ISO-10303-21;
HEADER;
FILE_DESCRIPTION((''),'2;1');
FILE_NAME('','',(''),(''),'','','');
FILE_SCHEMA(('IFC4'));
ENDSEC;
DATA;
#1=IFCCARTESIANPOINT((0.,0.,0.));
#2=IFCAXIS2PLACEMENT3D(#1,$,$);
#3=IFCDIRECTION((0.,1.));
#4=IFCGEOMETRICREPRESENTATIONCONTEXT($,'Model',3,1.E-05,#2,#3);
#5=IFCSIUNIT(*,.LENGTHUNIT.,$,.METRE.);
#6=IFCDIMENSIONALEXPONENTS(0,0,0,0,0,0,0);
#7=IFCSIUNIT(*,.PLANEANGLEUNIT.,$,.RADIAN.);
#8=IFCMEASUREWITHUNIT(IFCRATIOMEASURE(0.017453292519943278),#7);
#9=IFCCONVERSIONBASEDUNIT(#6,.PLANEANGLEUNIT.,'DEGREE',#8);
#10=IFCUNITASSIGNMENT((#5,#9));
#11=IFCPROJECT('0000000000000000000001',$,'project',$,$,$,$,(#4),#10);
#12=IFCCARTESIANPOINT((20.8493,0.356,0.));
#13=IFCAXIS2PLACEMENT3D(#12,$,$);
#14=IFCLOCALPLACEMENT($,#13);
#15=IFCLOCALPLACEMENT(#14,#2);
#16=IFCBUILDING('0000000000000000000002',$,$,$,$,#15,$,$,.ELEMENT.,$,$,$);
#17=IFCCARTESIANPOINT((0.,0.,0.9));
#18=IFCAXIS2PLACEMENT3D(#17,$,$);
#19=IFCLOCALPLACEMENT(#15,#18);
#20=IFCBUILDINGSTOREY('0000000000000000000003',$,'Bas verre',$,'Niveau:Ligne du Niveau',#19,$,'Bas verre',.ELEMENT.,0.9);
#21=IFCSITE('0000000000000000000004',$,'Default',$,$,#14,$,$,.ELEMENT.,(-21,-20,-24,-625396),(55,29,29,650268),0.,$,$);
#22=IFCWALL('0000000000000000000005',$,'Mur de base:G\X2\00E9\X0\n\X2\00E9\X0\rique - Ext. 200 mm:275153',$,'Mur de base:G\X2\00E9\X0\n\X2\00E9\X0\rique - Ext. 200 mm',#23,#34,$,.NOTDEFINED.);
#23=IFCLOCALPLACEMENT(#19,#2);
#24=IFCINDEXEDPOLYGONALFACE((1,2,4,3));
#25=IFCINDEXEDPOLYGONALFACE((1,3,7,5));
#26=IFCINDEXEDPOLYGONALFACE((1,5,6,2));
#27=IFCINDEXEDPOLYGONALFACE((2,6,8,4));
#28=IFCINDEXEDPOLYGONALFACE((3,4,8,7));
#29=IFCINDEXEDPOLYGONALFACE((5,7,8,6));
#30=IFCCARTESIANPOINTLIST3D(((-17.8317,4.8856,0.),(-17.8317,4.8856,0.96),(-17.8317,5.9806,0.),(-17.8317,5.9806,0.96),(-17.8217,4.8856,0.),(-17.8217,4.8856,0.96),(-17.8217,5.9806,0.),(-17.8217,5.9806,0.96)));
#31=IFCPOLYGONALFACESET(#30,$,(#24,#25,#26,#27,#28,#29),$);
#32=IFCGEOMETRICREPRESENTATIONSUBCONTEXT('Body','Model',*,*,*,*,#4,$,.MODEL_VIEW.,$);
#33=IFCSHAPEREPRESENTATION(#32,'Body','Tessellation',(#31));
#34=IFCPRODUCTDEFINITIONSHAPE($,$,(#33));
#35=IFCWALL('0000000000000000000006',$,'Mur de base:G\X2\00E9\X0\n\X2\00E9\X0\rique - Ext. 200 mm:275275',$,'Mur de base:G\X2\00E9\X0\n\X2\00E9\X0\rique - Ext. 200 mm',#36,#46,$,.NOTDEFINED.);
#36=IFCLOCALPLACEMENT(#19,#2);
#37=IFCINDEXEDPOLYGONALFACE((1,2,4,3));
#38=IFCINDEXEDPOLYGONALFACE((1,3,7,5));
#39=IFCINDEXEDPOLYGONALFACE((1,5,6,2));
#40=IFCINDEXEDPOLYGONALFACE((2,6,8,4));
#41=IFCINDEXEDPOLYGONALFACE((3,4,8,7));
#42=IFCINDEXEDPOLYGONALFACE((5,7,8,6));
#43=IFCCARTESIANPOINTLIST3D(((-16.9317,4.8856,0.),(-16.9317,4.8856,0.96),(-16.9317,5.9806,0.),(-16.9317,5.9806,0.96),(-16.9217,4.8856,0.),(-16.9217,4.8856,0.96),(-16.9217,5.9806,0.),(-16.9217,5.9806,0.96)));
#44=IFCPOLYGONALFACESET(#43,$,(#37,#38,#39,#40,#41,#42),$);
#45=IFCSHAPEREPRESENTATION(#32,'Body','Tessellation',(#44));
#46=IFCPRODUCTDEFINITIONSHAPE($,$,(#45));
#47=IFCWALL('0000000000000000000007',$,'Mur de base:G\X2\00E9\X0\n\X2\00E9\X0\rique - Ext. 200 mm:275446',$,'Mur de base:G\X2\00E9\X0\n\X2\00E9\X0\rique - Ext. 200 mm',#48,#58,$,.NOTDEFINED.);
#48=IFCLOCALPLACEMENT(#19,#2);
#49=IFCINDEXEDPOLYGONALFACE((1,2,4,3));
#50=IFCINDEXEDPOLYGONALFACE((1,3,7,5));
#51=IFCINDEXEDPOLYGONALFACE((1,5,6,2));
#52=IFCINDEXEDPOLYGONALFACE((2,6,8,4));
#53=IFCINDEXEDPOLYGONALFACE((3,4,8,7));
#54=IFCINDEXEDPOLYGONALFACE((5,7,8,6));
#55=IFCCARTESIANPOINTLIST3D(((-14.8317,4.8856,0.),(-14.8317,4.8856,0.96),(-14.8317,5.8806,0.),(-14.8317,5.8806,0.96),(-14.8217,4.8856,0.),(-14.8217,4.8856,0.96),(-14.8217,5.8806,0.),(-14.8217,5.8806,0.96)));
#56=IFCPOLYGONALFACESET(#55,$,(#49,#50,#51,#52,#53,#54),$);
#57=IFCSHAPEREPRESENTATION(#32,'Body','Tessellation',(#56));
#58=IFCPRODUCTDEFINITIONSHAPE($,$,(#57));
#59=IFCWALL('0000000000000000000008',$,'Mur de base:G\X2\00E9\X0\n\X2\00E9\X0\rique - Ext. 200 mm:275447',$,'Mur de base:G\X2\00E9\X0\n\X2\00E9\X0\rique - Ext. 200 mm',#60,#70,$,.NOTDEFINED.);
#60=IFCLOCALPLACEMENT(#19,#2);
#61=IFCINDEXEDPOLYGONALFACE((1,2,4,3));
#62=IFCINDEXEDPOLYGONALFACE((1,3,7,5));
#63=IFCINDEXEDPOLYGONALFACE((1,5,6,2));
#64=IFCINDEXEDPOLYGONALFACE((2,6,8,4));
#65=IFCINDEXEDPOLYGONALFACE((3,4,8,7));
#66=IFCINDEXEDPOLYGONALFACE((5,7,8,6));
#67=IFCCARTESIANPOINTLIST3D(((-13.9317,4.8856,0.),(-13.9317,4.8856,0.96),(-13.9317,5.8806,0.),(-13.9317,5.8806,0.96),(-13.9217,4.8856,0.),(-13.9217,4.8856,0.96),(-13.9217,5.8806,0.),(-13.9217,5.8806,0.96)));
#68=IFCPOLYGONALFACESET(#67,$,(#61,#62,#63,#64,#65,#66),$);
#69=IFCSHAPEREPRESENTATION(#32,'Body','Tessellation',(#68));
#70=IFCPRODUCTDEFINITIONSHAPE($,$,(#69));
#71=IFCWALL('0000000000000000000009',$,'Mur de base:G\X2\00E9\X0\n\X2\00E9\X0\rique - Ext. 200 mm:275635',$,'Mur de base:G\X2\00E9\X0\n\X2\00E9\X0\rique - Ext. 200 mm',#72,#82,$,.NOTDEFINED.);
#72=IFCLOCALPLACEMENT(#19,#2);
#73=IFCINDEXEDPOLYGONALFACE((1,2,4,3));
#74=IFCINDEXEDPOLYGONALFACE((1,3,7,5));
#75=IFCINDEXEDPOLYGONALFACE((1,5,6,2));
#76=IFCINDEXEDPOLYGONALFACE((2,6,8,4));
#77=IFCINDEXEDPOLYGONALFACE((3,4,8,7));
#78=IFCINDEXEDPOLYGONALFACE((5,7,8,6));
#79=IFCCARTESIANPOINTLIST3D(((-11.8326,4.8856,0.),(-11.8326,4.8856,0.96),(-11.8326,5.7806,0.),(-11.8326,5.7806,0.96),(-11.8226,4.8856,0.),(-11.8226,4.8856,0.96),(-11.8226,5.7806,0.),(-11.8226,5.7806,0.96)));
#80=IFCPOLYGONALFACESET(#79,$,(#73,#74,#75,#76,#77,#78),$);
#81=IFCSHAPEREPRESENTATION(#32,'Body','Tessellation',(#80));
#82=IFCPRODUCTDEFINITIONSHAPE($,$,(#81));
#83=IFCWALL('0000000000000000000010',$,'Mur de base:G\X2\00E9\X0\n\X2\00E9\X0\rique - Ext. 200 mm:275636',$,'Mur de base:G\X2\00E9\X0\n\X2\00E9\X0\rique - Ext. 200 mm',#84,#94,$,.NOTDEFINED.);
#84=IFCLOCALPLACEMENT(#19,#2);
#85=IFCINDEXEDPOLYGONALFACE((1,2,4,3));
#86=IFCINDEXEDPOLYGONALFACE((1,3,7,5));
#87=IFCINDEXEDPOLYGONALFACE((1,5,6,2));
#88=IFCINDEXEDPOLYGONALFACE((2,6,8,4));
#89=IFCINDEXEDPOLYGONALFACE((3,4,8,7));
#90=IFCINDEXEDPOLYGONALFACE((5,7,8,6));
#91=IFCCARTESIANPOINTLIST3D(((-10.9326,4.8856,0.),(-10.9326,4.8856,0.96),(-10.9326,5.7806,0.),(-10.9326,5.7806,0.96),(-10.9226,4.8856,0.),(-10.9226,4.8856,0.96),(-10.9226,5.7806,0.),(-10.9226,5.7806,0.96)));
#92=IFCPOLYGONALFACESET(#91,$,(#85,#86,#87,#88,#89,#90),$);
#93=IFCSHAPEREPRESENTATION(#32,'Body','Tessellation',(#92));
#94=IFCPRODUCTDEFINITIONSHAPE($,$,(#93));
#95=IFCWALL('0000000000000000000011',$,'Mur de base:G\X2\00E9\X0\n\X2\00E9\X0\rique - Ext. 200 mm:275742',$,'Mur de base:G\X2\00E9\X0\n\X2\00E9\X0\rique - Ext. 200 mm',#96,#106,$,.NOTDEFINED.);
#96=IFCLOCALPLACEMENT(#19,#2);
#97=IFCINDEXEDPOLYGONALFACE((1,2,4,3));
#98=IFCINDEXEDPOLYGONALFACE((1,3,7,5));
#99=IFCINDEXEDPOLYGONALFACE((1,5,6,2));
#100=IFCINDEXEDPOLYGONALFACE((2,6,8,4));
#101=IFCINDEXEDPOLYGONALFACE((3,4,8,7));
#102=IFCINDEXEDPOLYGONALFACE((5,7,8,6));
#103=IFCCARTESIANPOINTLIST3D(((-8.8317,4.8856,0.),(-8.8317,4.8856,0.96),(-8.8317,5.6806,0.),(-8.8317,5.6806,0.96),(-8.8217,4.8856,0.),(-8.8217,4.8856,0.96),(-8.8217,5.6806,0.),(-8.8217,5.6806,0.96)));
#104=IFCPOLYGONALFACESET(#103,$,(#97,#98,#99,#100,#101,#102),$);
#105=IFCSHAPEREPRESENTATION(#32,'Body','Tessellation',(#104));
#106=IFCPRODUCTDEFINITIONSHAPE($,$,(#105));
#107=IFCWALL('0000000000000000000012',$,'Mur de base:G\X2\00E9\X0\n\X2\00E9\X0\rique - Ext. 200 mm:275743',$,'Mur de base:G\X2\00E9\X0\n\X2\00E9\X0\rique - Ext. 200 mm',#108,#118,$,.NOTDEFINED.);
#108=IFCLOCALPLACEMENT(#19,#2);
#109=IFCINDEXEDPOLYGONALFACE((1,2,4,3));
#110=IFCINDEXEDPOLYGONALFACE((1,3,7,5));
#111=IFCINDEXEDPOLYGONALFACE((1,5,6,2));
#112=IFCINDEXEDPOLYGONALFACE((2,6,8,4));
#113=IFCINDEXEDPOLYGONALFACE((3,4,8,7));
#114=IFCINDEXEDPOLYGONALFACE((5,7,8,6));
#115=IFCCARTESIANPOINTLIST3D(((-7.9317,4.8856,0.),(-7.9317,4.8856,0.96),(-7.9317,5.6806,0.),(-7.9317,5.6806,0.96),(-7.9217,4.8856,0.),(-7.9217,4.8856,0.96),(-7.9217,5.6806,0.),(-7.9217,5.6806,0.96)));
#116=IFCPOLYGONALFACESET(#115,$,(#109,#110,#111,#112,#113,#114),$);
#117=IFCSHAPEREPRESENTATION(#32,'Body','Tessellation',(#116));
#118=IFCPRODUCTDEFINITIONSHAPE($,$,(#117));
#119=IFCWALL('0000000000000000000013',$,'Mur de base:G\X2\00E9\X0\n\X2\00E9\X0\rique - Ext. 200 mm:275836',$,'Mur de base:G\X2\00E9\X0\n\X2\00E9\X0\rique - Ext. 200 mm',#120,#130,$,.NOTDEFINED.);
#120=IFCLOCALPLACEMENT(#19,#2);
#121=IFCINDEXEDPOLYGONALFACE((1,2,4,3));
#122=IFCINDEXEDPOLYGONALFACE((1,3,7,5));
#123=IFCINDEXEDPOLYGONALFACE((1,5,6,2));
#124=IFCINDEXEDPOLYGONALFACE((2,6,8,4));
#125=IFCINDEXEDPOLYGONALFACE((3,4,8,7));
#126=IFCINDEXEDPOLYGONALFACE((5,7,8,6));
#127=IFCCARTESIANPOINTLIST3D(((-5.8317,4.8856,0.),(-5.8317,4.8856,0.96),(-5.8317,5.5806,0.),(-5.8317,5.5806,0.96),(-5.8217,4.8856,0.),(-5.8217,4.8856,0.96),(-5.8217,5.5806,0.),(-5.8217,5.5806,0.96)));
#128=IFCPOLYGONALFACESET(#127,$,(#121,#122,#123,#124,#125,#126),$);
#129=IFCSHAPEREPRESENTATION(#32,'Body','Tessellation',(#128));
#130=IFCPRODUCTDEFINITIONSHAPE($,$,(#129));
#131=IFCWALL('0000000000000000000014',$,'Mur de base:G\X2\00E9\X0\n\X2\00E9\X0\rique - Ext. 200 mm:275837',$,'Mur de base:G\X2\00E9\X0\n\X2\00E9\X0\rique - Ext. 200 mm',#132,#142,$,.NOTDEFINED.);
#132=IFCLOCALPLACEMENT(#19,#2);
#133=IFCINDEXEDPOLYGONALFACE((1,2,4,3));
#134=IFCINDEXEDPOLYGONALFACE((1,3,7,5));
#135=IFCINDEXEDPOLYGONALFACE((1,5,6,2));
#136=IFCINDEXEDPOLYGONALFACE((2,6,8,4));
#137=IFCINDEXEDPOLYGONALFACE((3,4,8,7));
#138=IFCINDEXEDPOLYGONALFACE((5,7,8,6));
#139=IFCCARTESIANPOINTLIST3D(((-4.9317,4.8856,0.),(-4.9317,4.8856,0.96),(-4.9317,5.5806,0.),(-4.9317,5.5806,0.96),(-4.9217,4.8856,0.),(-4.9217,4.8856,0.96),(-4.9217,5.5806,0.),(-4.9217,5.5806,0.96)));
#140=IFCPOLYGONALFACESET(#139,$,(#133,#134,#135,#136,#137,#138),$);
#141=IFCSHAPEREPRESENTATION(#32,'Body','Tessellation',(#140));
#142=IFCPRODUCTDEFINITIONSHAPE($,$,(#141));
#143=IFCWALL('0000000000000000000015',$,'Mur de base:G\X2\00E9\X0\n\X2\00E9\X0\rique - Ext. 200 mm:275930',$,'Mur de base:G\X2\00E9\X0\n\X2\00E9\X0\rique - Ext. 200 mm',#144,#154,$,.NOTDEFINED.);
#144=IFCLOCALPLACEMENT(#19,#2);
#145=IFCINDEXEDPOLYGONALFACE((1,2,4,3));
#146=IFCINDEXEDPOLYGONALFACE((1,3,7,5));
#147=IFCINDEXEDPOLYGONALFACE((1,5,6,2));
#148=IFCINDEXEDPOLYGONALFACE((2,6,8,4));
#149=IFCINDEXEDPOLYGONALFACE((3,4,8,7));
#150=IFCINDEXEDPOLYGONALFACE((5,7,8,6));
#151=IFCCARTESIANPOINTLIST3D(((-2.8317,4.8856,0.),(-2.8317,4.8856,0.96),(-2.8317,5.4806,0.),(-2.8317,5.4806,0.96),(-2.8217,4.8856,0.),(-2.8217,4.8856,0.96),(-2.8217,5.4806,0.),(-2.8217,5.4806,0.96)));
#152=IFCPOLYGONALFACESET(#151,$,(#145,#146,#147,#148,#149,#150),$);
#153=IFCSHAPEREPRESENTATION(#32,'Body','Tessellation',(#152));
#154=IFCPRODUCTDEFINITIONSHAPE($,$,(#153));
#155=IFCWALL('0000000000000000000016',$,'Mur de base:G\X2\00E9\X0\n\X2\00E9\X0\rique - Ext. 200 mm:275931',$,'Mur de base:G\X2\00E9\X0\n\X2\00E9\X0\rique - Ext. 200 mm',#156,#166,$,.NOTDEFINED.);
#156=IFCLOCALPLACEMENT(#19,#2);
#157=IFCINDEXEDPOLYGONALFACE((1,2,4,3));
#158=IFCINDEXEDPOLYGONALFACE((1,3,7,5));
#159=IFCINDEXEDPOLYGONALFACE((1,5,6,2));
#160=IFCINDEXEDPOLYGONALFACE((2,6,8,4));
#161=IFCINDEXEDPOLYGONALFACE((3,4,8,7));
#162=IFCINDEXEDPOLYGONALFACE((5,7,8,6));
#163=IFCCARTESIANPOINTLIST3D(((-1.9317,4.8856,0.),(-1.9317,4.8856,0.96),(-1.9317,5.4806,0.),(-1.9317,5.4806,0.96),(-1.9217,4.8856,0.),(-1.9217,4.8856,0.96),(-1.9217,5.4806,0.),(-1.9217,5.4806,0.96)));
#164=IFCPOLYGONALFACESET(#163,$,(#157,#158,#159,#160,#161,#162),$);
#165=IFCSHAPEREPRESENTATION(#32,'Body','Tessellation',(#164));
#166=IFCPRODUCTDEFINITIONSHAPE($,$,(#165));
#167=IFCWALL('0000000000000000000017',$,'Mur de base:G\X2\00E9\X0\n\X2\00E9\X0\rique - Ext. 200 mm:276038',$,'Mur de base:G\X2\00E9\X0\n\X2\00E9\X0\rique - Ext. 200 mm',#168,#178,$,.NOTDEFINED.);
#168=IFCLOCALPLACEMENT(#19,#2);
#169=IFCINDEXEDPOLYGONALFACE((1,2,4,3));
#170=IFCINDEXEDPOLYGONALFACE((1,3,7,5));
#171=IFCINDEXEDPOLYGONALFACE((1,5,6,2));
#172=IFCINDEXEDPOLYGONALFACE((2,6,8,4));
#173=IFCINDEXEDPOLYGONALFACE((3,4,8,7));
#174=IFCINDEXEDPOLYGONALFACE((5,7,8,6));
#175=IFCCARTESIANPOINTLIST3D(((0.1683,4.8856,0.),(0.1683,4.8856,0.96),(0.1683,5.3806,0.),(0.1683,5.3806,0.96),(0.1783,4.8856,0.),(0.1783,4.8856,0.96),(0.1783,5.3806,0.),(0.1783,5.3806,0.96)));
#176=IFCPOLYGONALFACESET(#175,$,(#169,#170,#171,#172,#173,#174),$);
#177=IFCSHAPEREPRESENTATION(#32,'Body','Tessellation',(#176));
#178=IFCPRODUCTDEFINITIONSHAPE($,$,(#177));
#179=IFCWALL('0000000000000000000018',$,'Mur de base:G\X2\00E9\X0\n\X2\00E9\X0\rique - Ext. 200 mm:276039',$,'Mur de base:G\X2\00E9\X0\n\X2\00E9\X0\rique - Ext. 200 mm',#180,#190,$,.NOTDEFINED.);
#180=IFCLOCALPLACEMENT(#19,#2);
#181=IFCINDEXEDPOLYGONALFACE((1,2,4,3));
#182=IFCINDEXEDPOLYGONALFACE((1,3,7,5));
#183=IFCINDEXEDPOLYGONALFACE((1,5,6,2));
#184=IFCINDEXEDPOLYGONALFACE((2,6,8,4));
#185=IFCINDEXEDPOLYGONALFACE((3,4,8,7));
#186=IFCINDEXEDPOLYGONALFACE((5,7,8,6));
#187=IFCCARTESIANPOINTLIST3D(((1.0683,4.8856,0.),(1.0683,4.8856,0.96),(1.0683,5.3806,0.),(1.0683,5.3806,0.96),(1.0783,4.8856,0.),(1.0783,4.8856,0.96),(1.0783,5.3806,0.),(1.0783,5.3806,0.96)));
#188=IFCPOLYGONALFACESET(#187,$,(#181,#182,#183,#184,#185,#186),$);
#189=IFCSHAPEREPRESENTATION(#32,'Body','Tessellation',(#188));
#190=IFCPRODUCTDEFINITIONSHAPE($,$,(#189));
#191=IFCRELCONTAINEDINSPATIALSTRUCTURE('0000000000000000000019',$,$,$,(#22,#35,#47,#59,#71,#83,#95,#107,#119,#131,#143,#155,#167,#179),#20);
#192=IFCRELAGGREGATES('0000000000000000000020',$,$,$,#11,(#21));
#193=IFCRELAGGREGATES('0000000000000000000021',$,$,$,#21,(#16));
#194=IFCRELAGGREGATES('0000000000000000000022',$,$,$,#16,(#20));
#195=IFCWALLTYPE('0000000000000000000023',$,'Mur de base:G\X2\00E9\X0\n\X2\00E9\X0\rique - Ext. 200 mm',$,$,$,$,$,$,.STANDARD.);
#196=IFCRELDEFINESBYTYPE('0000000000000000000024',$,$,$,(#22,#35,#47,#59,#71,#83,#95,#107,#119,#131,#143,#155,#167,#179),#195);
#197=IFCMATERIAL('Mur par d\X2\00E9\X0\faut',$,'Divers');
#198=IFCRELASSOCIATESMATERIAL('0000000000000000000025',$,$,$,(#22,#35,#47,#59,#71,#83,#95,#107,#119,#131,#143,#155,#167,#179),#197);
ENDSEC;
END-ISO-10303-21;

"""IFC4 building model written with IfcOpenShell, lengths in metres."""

from ifc_helpers import new_model, entity, si_unit, converted_unit, direction, frame, origin, place, context, subcontext, project, spatial, indexed_curve, outline, extrude, material, type_object, element, save


model = new_model("IFC4")

# Units and contexts
model_context = context("Model", 3, precision=1e-05, world=origin(), true_north=direction((0.0, 1.0)))
body_context = subcontext(model_context, "Body", "Model", "MODEL_VIEW")
ifc_project = project(units=[si_unit("LENGTHUNIT", "METRE"), converted_unit("PLANEANGLEUNIT", "DEGREE", entity("IfcRatioMeasure", 0.017453292519943278), si_unit("PLANEANGLEUNIT", "RADIAN"), dimensions=[0, 0, 0, 0, 0, 0, 0])], contexts=[model_context])

# Site, building, storey
site_placement = place(None, frame((20.8493, 0.356, 0.0)))
site = spatial("IfcSite", under=ifc_project, at=site_placement, Name="Default", CompositionType="ELEMENT", RefLatitude=(-21, -20, -24, -625396), RefLongitude=(55, 29, 29, 650268), RefElevation=0.0)
building_placement = place(site_placement, origin())
building = spatial("IfcBuilding", under=site, at=building_placement, CompositionType="ELEMENT")
storey_placement = place(building_placement, frame((0.0, 0.0, 0.9)))
storey = spatial("IfcBuildingStorey", under=building, at=storey_placement, Name="Bas verre", ObjectType="Niveau:Ligne du Niveau", LongName="Bas verre", CompositionType="ELEMENT", Elevation=0.9)

# Walls
ifc_material = material(Name="Mur par défaut", Category="Divers")
wall_type = type_object("IfcWallType", Name="Mur de base:Générique - Ext. 200 mm", PredefinedType="STANDARD")
wall_1_placement = place(storey_placement, frame((-17.8267, 4.8856, 0.0), z_axis=(0.0, 0.0, 1.0), x_axis=(0.0, 1.0, 0.0)))
element("IfcWall", 1, at=wall_1_placement, inside=storey, type_object=wall_type, material=ifc_material, Name="Mur de base:Générique - Ext. 200 mm:275153", ObjectType="Mur de base:Générique - Ext. 200 mm", PredefinedType="NOTDEFINED", context=body_context, shape_type="SweptSolid", body=[
    extrude(outline(indexed_curve([(1.095, 0.005), (0.0, 0.005), (0.0, -0.005), (1.095, -0.005), (1.095, 0.005)], self_intersect=False)), origin(), (0.0, 0.0, 1.0), 0.96),
])
wall_2_placement = place(storey_placement, frame((-16.9267, 4.8856, 0.0), z_axis=(0.0, 0.0, 1.0), x_axis=(0.0, 1.0, 0.0)))
element("IfcWall", 2, at=wall_2_placement, inside=storey, type_object=wall_type, material=ifc_material, Name="Mur de base:Générique - Ext. 200 mm:275275", ObjectType="Mur de base:Générique - Ext. 200 mm", PredefinedType="NOTDEFINED", context=body_context, shape_type="SweptSolid", body=[
    extrude(outline(indexed_curve([(1.095, 0.005), (0.0, 0.005), (0.0, -0.005), (1.095, -0.005), (1.095, 0.005)], self_intersect=False)), origin(), (0.0, 0.0, 1.0), 0.96),
])
wall_3_placement = place(storey_placement, frame((-14.8267, 4.8856, 0.0), z_axis=(0.0, 0.0, 1.0), x_axis=(0.0, 1.0, 0.0)))
element("IfcWall", 3, at=wall_3_placement, inside=storey, type_object=wall_type, material=ifc_material, Name="Mur de base:Générique - Ext. 200 mm:275446", ObjectType="Mur de base:Générique - Ext. 200 mm", PredefinedType="NOTDEFINED", context=body_context, shape_type="SweptSolid", body=[
    extrude(outline(indexed_curve([(0.995, 0.005), (0.0, 0.005), (0.0, -0.005), (0.995, -0.005), (0.995, 0.005)], self_intersect=False)), origin(), (0.0, 0.0, 1.0), 0.96),
])
wall_4_placement = place(storey_placement, frame((-13.9267, 4.8856, 0.0), z_axis=(0.0, 0.0, 1.0), x_axis=(0.0, 1.0, 0.0)))
element("IfcWall", 4, at=wall_4_placement, inside=storey, type_object=wall_type, material=ifc_material, Name="Mur de base:Générique - Ext. 200 mm:275447", ObjectType="Mur de base:Générique - Ext. 200 mm", PredefinedType="NOTDEFINED", context=body_context, shape_type="SweptSolid", body=[
    extrude(outline(indexed_curve([(0.995, 0.005), (0.0, 0.005), (0.0, -0.005), (0.995, -0.005), (0.995, 0.005)], self_intersect=False)), origin(), (0.0, 0.0, 1.0), 0.96),
])
wall_5_placement = place(storey_placement, frame((-11.8276, 4.8856, 0.0), z_axis=(0.0, 0.0, 1.0), x_axis=(0.0, 1.0, 0.0)))
element("IfcWall", 5, at=wall_5_placement, inside=storey, type_object=wall_type, material=ifc_material, Name="Mur de base:Générique - Ext. 200 mm:275635", ObjectType="Mur de base:Générique - Ext. 200 mm", PredefinedType="NOTDEFINED", context=body_context, shape_type="SweptSolid", body=[
    extrude(outline(indexed_curve([(0.895, 0.005), (0.0, 0.005), (0.0, -0.005), (0.895, -0.005), (0.895, 0.005)], self_intersect=False)), origin(), (0.0, 0.0, 1.0), 0.96),
])
wall_6_placement = place(storey_placement, frame((-10.9276, 4.8856, 0.0), z_axis=(0.0, 0.0, 1.0), x_axis=(0.0, 1.0, 0.0)))
element("IfcWall", 6, at=wall_6_placement, inside=storey, type_object=wall_type, material=ifc_material, Name="Mur de base:Générique - Ext. 200 mm:275636", ObjectType="Mur de base:Générique - Ext. 200 mm", PredefinedType="NOTDEFINED", context=body_context, shape_type="SweptSolid", body=[
    extrude(outline(indexed_curve([(0.895, 0.005), (0.0, 0.005), (0.0, -0.005), (0.895, -0.005), (0.895, 0.005)], self_intersect=False)), origin(), (0.0, 0.0, 1.0), 0.96),
])
wall_7_placement = place(storey_placement, frame((-8.8267, 4.8856, 0.0), z_axis=(0.0, 0.0, 1.0), x_axis=(0.0, 1.0, 0.0)))
element("IfcWall", 7, at=wall_7_placement, inside=storey, type_object=wall_type, material=ifc_material, Name="Mur de base:Générique - Ext. 200 mm:275742", ObjectType="Mur de base:Générique - Ext. 200 mm", PredefinedType="NOTDEFINED", context=body_context, shape_type="SweptSolid", body=[
    extrude(outline(indexed_curve([(0.795, 0.005), (0.0, 0.005), (0.0, -0.005), (0.795, -0.005), (0.795, 0.005)], self_intersect=False)), origin(), (0.0, 0.0, 1.0), 0.96),
])
wall_8_placement = place(storey_placement, frame((-7.9267, 4.8856, 0.0), z_axis=(0.0, 0.0, 1.0), x_axis=(0.0, 1.0, 0.0)))
element("IfcWall", 8, at=wall_8_placement, inside=storey, type_object=wall_type, material=ifc_material, Name="Mur de base:Générique - Ext. 200 mm:275743", ObjectType="Mur de base:Générique - Ext. 200 mm", PredefinedType="NOTDEFINED", context=body_context, shape_type="SweptSolid", body=[
    extrude(outline(indexed_curve([(0.795, 0.005), (0.0, 0.005), (0.0, -0.005), (0.795, -0.005), (0.795, 0.005)], self_intersect=False)), origin(), (0.0, 0.0, 1.0), 0.96),
])
wall_9_placement = place(storey_placement, frame((-5.8267, 4.8856, 0.0), z_axis=(0.0, 0.0, 1.0), x_axis=(0.0, 1.0, 0.0)))
element("IfcWall", 9, at=wall_9_placement, inside=storey, type_object=wall_type, material=ifc_material, Name="Mur de base:Générique - Ext. 200 mm:275836", ObjectType="Mur de base:Générique - Ext. 200 mm", PredefinedType="NOTDEFINED", context=body_context, shape_type="SweptSolid", body=[
    extrude(outline(indexed_curve([(0.695, 0.005), (0.0, 0.005), (0.0, -0.005), (0.695, -0.005), (0.695, 0.005)], self_intersect=False)), origin(), (0.0, 0.0, 1.0), 0.96),
])
wall_10_placement = place(storey_placement, frame((-4.9267, 4.8856, 0.0), z_axis=(0.0, 0.0, 1.0), x_axis=(0.0, 1.0, 0.0)))
element("IfcWall", 10, at=wall_10_placement, inside=storey, type_object=wall_type, material=ifc_material, Name="Mur de base:Générique - Ext. 200 mm:275837", ObjectType="Mur de base:Générique - Ext. 200 mm", PredefinedType="NOTDEFINED", context=body_context, shape_type="SweptSolid", body=[
    extrude(outline(indexed_curve([(0.695, 0.005), (0.0, 0.005), (0.0, -0.005), (0.695, -0.005), (0.695, 0.005)], self_intersect=False)), origin(), (0.0, 0.0, 1.0), 0.96),
])
wall_11_placement = place(storey_placement, frame((-2.8267, 4.8856, 0.0), z_axis=(0.0, 0.0, 1.0), x_axis=(0.0, 1.0, 0.0)))
element("IfcWall", 11, at=wall_11_placement, inside=storey, type_object=wall_type, material=ifc_material, Name="Mur de base:Générique - Ext. 200 mm:275930", ObjectType="Mur de base:Générique - Ext. 200 mm", PredefinedType="NOTDEFINED", context=body_context, shape_type="SweptSolid", body=[
    extrude(outline(indexed_curve([(0.595, 0.005), (0.0, 0.005), (0.0, -0.005), (0.595, -0.005), (0.595, 0.005)], self_intersect=False)), origin(), (0.0, 0.0, 1.0), 0.96),
])
wall_12_placement = place(storey_placement, frame((-1.9267, 4.8856, 0.0), z_axis=(0.0, 0.0, 1.0), x_axis=(0.0, 1.0, 0.0)))
element("IfcWall", 12, at=wall_12_placement, inside=storey, type_object=wall_type, material=ifc_material, Name="Mur de base:Générique - Ext. 200 mm:275931", ObjectType="Mur de base:Générique - Ext. 200 mm", PredefinedType="NOTDEFINED", context=body_context, shape_type="SweptSolid", body=[
    extrude(outline(indexed_curve([(0.595, 0.005), (0.0, 0.005), (0.0, -0.005), (0.595, -0.005), (0.595, 0.005)], self_intersect=False)), origin(), (0.0, 0.0, 1.0), 0.96),
])
wall_13_placement = place(storey_placement, frame((0.1733, 4.8856, 0.0), z_axis=(0.0, 0.0, 1.0), x_axis=(0.0, 1.0, 0.0)))
element("IfcWall", 13, at=wall_13_placement, inside=storey, type_object=wall_type, material=ifc_material, Name="Mur de base:Générique - Ext. 200 mm:276038", ObjectType="Mur de base:Générique - Ext. 200 mm", PredefinedType="NOTDEFINED", context=body_context, shape_type="SweptSolid", body=[
    extrude(outline(indexed_curve([(0.495, 0.005), (0.0, 0.005), (0.0, -0.005), (0.495, -0.005), (0.495, 0.005)], self_intersect=False)), origin(), (0.0, 0.0, 1.0), 0.96),
])
wall_14_placement = place(storey_placement, frame((1.0733, 4.8856, 0.0), z_axis=(0.0, 0.0, 1.0), x_axis=(0.0, 1.0, 0.0)))
element("IfcWall", 14, at=wall_14_placement, inside=storey, type_object=wall_type, material=ifc_material, Name="Mur de base:Générique - Ext. 200 mm:276039", ObjectType="Mur de base:Générique - Ext. 200 mm", PredefinedType="NOTDEFINED", context=body_context, shape_type="SweptSolid", body=[
    extrude(outline(indexed_curve([(0.495, 0.005), (0.0, 0.005), (0.0, -0.005), (0.495, -0.005), (0.495, 0.005)], self_intersect=False)), origin(), (0.0, 0.0, 1.0), 0.96),
])

save(model, "model.ifc")
